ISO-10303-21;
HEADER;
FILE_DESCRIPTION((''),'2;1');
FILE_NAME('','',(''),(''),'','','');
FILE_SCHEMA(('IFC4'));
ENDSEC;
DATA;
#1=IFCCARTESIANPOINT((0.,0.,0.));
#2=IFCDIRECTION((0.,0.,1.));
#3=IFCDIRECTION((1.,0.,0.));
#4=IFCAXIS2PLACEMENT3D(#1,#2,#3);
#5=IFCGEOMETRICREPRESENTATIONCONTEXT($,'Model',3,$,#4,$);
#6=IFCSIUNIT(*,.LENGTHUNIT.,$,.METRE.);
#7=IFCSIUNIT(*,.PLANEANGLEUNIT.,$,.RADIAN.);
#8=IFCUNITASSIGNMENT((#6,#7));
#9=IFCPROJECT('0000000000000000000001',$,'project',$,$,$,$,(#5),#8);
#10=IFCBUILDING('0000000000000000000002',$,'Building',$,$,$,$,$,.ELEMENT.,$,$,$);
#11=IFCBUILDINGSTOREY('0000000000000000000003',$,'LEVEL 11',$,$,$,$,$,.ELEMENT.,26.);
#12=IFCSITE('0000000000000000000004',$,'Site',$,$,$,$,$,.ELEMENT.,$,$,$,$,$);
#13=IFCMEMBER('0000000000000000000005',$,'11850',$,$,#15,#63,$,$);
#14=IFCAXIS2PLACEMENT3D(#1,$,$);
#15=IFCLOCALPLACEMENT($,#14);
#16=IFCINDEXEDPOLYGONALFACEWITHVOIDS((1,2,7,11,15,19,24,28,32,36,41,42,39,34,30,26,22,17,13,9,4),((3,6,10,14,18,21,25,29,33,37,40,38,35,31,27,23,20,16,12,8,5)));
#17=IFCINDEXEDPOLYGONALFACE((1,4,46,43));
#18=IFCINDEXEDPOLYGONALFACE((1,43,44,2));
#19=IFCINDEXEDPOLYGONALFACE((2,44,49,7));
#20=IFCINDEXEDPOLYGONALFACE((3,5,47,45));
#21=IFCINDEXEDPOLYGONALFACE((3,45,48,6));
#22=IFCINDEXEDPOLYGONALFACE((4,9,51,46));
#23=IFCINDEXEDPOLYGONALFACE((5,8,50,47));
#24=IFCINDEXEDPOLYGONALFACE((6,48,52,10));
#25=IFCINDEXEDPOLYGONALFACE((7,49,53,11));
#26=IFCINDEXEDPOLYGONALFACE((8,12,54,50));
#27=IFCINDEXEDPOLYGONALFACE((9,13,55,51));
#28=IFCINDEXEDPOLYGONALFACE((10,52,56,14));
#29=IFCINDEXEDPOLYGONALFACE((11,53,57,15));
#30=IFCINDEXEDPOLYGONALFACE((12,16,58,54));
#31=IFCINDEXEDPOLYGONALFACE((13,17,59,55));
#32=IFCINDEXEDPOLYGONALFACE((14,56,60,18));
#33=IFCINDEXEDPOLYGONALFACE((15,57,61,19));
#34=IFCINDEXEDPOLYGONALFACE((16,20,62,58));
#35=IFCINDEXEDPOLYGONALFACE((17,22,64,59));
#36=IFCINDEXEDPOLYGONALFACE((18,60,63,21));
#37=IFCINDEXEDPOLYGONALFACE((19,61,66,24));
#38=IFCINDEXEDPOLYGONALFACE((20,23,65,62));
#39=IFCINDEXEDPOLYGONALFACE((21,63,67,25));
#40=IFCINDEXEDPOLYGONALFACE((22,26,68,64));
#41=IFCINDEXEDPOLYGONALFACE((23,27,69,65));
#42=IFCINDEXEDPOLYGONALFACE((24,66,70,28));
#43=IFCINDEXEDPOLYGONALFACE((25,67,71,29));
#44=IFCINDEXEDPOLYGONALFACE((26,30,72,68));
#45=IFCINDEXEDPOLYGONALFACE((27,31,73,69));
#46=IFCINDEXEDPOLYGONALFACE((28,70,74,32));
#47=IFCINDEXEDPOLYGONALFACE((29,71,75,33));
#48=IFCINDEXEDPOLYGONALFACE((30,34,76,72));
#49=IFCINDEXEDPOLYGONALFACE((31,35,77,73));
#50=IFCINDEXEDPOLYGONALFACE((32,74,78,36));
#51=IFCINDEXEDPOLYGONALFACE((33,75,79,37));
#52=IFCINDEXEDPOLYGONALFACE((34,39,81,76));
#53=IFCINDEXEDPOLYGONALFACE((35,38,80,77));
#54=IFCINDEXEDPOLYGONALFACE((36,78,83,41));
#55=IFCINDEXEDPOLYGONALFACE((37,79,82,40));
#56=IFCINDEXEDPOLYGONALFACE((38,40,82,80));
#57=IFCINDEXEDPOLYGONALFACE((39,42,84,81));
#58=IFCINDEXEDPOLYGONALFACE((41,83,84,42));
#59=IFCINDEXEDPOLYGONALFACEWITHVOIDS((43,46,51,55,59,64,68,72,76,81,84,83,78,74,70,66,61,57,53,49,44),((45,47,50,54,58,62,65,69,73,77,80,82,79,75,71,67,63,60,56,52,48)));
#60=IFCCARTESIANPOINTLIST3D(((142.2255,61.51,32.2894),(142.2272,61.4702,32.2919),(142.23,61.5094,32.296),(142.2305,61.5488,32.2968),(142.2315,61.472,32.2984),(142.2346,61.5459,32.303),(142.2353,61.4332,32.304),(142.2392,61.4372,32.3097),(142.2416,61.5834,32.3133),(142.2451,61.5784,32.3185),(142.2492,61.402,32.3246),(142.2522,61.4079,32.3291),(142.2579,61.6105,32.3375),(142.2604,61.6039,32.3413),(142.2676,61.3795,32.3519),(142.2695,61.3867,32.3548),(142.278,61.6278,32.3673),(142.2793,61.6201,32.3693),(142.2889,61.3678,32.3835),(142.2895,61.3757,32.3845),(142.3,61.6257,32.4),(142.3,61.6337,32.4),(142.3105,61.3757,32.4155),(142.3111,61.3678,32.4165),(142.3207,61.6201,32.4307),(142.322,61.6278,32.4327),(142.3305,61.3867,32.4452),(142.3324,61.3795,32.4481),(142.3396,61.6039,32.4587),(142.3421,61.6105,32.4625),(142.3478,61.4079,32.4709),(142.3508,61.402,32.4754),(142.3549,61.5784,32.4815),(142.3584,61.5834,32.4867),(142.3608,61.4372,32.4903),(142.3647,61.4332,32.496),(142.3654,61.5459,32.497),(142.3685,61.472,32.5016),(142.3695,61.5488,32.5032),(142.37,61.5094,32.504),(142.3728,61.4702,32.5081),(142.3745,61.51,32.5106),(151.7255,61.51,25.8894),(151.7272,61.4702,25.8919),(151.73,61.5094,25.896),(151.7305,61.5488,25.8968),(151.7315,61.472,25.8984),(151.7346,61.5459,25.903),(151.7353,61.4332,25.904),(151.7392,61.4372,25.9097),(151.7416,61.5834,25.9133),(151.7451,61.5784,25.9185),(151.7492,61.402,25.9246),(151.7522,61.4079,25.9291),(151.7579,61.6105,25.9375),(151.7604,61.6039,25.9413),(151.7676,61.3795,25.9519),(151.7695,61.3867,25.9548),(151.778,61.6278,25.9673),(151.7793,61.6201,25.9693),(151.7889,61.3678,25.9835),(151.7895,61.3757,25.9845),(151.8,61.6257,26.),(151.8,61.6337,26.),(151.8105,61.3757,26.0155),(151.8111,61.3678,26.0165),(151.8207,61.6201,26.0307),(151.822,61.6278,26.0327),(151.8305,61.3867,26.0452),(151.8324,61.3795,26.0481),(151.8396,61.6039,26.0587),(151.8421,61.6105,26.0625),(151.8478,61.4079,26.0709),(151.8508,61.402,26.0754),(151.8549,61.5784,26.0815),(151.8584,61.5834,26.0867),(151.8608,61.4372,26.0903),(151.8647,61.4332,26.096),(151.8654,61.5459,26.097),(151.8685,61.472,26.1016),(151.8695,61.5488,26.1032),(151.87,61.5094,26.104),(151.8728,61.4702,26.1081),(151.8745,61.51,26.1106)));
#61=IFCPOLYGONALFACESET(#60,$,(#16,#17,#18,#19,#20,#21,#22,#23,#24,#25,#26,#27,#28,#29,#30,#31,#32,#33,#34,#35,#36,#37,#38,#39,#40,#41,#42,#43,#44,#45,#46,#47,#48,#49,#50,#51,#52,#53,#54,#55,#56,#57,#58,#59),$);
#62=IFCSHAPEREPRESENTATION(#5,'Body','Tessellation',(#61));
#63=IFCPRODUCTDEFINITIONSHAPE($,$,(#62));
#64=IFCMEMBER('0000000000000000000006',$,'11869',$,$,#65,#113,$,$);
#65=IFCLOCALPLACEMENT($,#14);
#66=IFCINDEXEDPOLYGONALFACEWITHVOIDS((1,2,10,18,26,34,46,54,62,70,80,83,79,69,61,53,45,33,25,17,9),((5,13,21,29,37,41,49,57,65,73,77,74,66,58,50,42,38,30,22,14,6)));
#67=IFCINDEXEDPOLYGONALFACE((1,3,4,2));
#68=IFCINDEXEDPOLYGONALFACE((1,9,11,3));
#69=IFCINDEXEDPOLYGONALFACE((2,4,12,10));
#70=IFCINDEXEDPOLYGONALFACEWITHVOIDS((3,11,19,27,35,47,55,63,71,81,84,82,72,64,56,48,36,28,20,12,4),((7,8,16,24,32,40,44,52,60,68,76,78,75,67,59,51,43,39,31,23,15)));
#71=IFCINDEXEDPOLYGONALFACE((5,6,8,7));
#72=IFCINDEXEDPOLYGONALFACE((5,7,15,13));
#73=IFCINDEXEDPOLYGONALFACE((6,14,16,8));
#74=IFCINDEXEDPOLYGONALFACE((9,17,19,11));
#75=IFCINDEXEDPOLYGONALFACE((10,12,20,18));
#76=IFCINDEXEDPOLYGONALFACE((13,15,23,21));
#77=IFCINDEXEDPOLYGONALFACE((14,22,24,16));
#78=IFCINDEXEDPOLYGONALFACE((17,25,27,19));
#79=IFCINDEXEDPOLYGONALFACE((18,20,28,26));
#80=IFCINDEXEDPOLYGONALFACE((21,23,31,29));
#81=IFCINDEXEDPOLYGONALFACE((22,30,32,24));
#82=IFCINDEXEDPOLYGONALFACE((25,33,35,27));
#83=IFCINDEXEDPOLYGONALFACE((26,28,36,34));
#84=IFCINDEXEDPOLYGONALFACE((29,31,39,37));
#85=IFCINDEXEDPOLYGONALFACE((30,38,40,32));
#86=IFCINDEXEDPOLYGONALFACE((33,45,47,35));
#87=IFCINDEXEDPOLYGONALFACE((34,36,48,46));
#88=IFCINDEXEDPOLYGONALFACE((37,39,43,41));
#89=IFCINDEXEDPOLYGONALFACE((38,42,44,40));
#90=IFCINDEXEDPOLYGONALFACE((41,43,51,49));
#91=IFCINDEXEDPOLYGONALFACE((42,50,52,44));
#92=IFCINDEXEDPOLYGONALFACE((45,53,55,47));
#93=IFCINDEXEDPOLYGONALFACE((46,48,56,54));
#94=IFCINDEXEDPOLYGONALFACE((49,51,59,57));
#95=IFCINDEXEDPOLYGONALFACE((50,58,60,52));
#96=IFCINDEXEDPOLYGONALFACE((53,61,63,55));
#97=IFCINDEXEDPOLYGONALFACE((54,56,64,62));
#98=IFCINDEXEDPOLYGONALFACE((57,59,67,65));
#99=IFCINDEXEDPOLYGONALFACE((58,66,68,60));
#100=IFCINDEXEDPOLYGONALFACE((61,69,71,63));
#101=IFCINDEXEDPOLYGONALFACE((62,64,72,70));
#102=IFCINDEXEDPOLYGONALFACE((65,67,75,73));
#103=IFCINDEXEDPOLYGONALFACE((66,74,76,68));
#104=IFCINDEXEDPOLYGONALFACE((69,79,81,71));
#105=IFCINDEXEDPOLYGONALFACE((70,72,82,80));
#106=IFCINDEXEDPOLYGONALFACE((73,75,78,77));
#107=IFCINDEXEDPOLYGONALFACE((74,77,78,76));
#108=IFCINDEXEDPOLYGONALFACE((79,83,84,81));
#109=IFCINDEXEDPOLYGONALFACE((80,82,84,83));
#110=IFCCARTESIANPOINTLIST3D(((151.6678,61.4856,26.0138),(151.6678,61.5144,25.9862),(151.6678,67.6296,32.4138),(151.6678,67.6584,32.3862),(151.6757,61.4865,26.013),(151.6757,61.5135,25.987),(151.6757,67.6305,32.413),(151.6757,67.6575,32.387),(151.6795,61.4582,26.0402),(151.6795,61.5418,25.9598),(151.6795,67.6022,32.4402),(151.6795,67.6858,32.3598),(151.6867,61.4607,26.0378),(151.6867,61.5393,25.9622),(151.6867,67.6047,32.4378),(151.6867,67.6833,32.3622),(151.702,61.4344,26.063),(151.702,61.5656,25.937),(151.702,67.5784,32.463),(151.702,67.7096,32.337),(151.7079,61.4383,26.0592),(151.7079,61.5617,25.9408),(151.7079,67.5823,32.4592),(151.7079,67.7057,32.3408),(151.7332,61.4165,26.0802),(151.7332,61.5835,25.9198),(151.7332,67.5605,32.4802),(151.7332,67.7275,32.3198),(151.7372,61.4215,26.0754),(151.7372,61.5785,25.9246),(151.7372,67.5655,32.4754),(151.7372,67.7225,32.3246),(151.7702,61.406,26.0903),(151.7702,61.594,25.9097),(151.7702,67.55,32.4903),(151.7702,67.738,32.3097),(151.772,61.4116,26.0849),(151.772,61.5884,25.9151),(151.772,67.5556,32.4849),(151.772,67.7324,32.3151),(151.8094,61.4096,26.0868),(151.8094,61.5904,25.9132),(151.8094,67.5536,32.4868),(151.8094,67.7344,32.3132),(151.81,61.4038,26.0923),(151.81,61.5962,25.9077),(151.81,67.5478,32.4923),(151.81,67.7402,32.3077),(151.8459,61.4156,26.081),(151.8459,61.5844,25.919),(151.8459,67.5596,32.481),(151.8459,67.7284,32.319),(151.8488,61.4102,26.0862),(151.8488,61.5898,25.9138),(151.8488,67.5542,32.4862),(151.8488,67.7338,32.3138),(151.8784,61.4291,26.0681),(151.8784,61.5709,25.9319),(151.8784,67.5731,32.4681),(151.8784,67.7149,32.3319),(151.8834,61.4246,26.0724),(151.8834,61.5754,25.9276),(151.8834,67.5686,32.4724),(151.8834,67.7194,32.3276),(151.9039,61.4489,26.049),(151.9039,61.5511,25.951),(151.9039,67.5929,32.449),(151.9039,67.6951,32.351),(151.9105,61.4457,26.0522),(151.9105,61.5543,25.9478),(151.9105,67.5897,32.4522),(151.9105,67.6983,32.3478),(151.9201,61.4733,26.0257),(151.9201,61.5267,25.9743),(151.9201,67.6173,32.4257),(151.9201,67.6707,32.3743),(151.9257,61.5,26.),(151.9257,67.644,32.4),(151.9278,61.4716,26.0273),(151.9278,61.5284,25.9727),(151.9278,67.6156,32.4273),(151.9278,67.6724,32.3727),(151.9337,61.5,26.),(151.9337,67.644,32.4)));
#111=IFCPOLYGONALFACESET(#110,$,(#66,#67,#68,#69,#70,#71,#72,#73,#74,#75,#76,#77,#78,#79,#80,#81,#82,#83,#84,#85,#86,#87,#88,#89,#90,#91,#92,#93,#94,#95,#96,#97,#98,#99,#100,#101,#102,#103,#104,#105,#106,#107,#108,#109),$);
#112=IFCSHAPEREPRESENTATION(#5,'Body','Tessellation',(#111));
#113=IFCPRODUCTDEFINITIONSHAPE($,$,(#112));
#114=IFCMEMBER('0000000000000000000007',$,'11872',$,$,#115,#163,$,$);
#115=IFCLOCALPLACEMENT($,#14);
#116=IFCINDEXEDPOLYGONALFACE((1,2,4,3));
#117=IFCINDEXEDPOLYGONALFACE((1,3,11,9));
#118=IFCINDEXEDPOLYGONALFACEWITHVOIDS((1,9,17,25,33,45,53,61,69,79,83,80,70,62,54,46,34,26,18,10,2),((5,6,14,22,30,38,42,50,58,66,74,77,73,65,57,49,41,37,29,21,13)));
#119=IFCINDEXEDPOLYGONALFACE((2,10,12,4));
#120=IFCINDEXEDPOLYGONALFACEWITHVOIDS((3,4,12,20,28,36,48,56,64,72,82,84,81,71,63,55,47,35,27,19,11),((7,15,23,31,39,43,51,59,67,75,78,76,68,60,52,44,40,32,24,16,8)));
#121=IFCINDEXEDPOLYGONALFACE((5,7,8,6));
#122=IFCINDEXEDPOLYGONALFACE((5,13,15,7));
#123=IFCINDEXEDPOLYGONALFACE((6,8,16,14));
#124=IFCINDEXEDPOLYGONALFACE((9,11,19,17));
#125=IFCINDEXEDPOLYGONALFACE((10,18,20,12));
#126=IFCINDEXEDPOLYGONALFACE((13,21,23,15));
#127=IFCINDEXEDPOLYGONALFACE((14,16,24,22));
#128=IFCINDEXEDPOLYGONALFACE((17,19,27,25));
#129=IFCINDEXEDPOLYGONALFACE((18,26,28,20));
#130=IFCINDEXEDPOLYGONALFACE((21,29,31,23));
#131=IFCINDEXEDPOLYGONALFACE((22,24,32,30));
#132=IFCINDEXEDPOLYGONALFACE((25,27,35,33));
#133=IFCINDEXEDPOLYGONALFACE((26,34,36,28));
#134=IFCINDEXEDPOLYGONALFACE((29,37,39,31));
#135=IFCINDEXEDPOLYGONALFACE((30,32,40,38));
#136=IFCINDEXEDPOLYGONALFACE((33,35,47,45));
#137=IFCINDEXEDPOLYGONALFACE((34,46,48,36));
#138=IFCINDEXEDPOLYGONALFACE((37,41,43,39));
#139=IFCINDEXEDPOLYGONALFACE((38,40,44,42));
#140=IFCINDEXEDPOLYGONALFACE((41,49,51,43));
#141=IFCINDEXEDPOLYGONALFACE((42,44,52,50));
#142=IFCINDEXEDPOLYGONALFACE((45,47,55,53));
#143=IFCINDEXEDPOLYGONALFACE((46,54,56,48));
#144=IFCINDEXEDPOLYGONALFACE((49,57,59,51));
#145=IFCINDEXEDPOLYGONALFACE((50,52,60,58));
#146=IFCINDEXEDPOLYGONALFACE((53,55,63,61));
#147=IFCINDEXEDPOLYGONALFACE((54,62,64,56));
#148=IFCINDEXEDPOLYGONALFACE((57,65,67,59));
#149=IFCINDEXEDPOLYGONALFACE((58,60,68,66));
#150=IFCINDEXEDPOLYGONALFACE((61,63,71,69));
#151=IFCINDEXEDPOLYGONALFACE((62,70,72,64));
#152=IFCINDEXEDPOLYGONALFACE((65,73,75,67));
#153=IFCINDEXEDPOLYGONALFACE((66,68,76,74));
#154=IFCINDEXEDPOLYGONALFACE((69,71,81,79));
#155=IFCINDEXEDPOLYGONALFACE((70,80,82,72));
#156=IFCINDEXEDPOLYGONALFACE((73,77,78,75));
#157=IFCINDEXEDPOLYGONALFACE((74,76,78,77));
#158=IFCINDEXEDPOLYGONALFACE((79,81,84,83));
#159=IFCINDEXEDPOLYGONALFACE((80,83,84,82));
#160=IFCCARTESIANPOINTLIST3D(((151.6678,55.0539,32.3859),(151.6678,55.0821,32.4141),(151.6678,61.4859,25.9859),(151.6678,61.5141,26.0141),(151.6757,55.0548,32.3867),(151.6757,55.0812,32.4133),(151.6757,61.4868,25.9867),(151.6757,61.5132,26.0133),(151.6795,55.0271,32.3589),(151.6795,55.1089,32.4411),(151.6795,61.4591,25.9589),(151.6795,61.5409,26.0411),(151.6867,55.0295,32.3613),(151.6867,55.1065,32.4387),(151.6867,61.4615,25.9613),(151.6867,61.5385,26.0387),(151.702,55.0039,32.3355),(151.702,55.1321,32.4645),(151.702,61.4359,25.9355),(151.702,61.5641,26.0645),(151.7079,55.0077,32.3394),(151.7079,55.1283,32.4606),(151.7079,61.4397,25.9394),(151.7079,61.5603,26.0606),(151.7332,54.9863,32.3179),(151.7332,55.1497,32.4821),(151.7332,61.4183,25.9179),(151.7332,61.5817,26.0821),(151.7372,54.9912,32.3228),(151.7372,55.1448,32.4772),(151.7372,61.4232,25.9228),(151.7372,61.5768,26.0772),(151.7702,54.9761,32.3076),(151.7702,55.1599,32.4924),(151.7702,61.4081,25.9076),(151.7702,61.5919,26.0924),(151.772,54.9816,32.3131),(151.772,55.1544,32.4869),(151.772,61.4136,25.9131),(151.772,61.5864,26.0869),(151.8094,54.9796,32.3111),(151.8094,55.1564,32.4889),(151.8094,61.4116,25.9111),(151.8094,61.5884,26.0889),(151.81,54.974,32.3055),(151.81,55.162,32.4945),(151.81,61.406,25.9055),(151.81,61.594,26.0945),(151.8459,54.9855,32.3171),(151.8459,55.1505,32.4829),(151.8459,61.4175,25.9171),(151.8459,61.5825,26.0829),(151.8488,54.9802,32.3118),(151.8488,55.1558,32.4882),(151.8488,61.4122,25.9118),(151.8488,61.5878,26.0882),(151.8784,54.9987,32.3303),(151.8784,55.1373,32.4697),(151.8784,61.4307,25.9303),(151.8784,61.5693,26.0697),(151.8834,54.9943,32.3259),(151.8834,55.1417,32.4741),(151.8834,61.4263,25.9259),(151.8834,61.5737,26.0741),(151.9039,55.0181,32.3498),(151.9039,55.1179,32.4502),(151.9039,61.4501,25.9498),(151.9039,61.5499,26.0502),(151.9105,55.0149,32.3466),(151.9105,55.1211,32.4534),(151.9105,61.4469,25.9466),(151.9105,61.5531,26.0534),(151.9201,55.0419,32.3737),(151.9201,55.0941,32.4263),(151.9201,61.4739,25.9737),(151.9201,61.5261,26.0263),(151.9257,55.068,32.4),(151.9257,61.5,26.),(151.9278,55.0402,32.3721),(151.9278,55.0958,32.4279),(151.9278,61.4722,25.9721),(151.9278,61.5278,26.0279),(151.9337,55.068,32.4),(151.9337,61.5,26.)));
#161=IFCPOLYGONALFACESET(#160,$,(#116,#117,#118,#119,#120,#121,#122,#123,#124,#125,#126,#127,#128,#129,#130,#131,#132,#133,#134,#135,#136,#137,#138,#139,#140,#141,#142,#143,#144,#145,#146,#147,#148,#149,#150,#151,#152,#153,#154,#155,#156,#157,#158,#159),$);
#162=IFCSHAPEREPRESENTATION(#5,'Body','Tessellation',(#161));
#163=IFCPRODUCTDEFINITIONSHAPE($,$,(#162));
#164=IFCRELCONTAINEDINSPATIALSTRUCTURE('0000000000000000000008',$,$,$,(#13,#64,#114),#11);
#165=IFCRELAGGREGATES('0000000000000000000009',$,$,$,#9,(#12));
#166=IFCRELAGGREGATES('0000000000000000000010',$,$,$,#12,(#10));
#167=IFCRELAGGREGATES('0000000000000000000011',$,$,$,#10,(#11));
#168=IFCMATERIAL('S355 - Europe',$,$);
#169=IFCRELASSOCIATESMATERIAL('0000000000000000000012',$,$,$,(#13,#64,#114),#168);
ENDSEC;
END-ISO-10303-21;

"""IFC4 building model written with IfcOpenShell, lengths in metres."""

from ifc_helpers import new_model, si_unit, frame, origin_with_axes, origin_2d_with_axis, place, context, project, spatial, hollow_circle, extrude, material, material_profile, profile_set, profile_usage, element, save


model = new_model("IFC4")

# Units and contexts
model_context = context("Model", 3, world=origin_with_axes())
ifc_project = project(units=[si_unit("LENGTHUNIT", "METRE"), si_unit("PLANEANGLEUNIT", "RADIAN")], contexts=[model_context])

# Site, building, storey
site = spatial("IfcSite", under=ifc_project, Name="Site", CompositionType="ELEMENT")
building = spatial("IfcBuilding", under=site, Name="Building", CompositionType="ELEMENT")
storey = spatial("IfcBuildingStorey", under=building, Name="LEVEL 11", CompositionType="ELEMENT", Elevation=26.0)

# Shared definitions
ifc_material = material(Name="S355 - Europe")

# Members
ifc_material_profile_1 = material_profile(ifc_material, hollow_circle(Radius=0.1337, WallThickness=0.008, at=origin_2d_with_axis()))
ifc_profile_set_1 = profile_set([ifc_material_profile_1])
ifc_profile_usage_1 = profile_usage(ifc_profile_set_1, cardinal=10)
member_1_placement = place(None, frame((142.3, 61.5, 32.4), z_axis=(0.829354, 0.0, -0.558723), x_axis=(0.0, 1.0, 0.0)))
element("IfcMember", 1, at=member_1_placement, inside=storey, material=ifc_profile_usage_1, Name="11850", context=model_context, shape_type="SweptSolid", body=[
    extrude(hollow_circle(Radius=0.1337, WallThickness=0.008, at=origin_2d_with_axis()), origin_with_axes(), (0.0, 0.0, 1.0), 11.4547),
])
ifc_material_profile_2 = material_profile(ifc_material, hollow_circle(Radius=0.1337, WallThickness=0.008, at=origin_2d_with_axis()))
ifc_profile_set_2 = profile_set([ifc_material_profile_2])
ifc_profile_usage_2 = profile_usage(ifc_profile_set_2, cardinal=10)
member_2_placement = place(None, frame((151.8, 67.644, 32.4), z_axis=(0.0, -0.692532, -0.721387), x_axis=(1.0, 0.0, 0.0)))
element("IfcMember", 2, at=member_2_placement, inside=storey, material=ifc_profile_usage_2, Name="11869", context=model_context, shape_type="SweptSolid", body=[
    extrude(hollow_circle(Radius=0.1337, WallThickness=0.008, at=origin_2d_with_axis()), origin_with_axes(), (0.0, 0.0, 1.0), 8.8718),
])
ifc_material_profile_3 = material_profile(ifc_material, hollow_circle(Radius=0.1337, WallThickness=0.008, at=origin_2d_with_axis()))
ifc_profile_set_3 = profile_set([ifc_material_profile_3])
ifc_profile_usage_3 = profile_usage(ifc_profile_set_3, cardinal=10)
member_3_placement = place(None, frame((151.8, 61.5, 26.0), z_axis=(0.0, -0.708868, 0.705341), x_axis=(1.0, 0.0, 0.0)))
element("IfcMember", 3, at=member_3_placement, inside=storey, material=ifc_profile_usage_3, Name="11872", context=model_context, shape_type="SweptSolid", body=[
    extrude(hollow_circle(Radius=0.1337, WallThickness=0.008, at=origin_2d_with_axis()), origin_with_axes(), (0.0, 0.0, 1.0), 9.0736),
])

save(model, "model.ifc")
